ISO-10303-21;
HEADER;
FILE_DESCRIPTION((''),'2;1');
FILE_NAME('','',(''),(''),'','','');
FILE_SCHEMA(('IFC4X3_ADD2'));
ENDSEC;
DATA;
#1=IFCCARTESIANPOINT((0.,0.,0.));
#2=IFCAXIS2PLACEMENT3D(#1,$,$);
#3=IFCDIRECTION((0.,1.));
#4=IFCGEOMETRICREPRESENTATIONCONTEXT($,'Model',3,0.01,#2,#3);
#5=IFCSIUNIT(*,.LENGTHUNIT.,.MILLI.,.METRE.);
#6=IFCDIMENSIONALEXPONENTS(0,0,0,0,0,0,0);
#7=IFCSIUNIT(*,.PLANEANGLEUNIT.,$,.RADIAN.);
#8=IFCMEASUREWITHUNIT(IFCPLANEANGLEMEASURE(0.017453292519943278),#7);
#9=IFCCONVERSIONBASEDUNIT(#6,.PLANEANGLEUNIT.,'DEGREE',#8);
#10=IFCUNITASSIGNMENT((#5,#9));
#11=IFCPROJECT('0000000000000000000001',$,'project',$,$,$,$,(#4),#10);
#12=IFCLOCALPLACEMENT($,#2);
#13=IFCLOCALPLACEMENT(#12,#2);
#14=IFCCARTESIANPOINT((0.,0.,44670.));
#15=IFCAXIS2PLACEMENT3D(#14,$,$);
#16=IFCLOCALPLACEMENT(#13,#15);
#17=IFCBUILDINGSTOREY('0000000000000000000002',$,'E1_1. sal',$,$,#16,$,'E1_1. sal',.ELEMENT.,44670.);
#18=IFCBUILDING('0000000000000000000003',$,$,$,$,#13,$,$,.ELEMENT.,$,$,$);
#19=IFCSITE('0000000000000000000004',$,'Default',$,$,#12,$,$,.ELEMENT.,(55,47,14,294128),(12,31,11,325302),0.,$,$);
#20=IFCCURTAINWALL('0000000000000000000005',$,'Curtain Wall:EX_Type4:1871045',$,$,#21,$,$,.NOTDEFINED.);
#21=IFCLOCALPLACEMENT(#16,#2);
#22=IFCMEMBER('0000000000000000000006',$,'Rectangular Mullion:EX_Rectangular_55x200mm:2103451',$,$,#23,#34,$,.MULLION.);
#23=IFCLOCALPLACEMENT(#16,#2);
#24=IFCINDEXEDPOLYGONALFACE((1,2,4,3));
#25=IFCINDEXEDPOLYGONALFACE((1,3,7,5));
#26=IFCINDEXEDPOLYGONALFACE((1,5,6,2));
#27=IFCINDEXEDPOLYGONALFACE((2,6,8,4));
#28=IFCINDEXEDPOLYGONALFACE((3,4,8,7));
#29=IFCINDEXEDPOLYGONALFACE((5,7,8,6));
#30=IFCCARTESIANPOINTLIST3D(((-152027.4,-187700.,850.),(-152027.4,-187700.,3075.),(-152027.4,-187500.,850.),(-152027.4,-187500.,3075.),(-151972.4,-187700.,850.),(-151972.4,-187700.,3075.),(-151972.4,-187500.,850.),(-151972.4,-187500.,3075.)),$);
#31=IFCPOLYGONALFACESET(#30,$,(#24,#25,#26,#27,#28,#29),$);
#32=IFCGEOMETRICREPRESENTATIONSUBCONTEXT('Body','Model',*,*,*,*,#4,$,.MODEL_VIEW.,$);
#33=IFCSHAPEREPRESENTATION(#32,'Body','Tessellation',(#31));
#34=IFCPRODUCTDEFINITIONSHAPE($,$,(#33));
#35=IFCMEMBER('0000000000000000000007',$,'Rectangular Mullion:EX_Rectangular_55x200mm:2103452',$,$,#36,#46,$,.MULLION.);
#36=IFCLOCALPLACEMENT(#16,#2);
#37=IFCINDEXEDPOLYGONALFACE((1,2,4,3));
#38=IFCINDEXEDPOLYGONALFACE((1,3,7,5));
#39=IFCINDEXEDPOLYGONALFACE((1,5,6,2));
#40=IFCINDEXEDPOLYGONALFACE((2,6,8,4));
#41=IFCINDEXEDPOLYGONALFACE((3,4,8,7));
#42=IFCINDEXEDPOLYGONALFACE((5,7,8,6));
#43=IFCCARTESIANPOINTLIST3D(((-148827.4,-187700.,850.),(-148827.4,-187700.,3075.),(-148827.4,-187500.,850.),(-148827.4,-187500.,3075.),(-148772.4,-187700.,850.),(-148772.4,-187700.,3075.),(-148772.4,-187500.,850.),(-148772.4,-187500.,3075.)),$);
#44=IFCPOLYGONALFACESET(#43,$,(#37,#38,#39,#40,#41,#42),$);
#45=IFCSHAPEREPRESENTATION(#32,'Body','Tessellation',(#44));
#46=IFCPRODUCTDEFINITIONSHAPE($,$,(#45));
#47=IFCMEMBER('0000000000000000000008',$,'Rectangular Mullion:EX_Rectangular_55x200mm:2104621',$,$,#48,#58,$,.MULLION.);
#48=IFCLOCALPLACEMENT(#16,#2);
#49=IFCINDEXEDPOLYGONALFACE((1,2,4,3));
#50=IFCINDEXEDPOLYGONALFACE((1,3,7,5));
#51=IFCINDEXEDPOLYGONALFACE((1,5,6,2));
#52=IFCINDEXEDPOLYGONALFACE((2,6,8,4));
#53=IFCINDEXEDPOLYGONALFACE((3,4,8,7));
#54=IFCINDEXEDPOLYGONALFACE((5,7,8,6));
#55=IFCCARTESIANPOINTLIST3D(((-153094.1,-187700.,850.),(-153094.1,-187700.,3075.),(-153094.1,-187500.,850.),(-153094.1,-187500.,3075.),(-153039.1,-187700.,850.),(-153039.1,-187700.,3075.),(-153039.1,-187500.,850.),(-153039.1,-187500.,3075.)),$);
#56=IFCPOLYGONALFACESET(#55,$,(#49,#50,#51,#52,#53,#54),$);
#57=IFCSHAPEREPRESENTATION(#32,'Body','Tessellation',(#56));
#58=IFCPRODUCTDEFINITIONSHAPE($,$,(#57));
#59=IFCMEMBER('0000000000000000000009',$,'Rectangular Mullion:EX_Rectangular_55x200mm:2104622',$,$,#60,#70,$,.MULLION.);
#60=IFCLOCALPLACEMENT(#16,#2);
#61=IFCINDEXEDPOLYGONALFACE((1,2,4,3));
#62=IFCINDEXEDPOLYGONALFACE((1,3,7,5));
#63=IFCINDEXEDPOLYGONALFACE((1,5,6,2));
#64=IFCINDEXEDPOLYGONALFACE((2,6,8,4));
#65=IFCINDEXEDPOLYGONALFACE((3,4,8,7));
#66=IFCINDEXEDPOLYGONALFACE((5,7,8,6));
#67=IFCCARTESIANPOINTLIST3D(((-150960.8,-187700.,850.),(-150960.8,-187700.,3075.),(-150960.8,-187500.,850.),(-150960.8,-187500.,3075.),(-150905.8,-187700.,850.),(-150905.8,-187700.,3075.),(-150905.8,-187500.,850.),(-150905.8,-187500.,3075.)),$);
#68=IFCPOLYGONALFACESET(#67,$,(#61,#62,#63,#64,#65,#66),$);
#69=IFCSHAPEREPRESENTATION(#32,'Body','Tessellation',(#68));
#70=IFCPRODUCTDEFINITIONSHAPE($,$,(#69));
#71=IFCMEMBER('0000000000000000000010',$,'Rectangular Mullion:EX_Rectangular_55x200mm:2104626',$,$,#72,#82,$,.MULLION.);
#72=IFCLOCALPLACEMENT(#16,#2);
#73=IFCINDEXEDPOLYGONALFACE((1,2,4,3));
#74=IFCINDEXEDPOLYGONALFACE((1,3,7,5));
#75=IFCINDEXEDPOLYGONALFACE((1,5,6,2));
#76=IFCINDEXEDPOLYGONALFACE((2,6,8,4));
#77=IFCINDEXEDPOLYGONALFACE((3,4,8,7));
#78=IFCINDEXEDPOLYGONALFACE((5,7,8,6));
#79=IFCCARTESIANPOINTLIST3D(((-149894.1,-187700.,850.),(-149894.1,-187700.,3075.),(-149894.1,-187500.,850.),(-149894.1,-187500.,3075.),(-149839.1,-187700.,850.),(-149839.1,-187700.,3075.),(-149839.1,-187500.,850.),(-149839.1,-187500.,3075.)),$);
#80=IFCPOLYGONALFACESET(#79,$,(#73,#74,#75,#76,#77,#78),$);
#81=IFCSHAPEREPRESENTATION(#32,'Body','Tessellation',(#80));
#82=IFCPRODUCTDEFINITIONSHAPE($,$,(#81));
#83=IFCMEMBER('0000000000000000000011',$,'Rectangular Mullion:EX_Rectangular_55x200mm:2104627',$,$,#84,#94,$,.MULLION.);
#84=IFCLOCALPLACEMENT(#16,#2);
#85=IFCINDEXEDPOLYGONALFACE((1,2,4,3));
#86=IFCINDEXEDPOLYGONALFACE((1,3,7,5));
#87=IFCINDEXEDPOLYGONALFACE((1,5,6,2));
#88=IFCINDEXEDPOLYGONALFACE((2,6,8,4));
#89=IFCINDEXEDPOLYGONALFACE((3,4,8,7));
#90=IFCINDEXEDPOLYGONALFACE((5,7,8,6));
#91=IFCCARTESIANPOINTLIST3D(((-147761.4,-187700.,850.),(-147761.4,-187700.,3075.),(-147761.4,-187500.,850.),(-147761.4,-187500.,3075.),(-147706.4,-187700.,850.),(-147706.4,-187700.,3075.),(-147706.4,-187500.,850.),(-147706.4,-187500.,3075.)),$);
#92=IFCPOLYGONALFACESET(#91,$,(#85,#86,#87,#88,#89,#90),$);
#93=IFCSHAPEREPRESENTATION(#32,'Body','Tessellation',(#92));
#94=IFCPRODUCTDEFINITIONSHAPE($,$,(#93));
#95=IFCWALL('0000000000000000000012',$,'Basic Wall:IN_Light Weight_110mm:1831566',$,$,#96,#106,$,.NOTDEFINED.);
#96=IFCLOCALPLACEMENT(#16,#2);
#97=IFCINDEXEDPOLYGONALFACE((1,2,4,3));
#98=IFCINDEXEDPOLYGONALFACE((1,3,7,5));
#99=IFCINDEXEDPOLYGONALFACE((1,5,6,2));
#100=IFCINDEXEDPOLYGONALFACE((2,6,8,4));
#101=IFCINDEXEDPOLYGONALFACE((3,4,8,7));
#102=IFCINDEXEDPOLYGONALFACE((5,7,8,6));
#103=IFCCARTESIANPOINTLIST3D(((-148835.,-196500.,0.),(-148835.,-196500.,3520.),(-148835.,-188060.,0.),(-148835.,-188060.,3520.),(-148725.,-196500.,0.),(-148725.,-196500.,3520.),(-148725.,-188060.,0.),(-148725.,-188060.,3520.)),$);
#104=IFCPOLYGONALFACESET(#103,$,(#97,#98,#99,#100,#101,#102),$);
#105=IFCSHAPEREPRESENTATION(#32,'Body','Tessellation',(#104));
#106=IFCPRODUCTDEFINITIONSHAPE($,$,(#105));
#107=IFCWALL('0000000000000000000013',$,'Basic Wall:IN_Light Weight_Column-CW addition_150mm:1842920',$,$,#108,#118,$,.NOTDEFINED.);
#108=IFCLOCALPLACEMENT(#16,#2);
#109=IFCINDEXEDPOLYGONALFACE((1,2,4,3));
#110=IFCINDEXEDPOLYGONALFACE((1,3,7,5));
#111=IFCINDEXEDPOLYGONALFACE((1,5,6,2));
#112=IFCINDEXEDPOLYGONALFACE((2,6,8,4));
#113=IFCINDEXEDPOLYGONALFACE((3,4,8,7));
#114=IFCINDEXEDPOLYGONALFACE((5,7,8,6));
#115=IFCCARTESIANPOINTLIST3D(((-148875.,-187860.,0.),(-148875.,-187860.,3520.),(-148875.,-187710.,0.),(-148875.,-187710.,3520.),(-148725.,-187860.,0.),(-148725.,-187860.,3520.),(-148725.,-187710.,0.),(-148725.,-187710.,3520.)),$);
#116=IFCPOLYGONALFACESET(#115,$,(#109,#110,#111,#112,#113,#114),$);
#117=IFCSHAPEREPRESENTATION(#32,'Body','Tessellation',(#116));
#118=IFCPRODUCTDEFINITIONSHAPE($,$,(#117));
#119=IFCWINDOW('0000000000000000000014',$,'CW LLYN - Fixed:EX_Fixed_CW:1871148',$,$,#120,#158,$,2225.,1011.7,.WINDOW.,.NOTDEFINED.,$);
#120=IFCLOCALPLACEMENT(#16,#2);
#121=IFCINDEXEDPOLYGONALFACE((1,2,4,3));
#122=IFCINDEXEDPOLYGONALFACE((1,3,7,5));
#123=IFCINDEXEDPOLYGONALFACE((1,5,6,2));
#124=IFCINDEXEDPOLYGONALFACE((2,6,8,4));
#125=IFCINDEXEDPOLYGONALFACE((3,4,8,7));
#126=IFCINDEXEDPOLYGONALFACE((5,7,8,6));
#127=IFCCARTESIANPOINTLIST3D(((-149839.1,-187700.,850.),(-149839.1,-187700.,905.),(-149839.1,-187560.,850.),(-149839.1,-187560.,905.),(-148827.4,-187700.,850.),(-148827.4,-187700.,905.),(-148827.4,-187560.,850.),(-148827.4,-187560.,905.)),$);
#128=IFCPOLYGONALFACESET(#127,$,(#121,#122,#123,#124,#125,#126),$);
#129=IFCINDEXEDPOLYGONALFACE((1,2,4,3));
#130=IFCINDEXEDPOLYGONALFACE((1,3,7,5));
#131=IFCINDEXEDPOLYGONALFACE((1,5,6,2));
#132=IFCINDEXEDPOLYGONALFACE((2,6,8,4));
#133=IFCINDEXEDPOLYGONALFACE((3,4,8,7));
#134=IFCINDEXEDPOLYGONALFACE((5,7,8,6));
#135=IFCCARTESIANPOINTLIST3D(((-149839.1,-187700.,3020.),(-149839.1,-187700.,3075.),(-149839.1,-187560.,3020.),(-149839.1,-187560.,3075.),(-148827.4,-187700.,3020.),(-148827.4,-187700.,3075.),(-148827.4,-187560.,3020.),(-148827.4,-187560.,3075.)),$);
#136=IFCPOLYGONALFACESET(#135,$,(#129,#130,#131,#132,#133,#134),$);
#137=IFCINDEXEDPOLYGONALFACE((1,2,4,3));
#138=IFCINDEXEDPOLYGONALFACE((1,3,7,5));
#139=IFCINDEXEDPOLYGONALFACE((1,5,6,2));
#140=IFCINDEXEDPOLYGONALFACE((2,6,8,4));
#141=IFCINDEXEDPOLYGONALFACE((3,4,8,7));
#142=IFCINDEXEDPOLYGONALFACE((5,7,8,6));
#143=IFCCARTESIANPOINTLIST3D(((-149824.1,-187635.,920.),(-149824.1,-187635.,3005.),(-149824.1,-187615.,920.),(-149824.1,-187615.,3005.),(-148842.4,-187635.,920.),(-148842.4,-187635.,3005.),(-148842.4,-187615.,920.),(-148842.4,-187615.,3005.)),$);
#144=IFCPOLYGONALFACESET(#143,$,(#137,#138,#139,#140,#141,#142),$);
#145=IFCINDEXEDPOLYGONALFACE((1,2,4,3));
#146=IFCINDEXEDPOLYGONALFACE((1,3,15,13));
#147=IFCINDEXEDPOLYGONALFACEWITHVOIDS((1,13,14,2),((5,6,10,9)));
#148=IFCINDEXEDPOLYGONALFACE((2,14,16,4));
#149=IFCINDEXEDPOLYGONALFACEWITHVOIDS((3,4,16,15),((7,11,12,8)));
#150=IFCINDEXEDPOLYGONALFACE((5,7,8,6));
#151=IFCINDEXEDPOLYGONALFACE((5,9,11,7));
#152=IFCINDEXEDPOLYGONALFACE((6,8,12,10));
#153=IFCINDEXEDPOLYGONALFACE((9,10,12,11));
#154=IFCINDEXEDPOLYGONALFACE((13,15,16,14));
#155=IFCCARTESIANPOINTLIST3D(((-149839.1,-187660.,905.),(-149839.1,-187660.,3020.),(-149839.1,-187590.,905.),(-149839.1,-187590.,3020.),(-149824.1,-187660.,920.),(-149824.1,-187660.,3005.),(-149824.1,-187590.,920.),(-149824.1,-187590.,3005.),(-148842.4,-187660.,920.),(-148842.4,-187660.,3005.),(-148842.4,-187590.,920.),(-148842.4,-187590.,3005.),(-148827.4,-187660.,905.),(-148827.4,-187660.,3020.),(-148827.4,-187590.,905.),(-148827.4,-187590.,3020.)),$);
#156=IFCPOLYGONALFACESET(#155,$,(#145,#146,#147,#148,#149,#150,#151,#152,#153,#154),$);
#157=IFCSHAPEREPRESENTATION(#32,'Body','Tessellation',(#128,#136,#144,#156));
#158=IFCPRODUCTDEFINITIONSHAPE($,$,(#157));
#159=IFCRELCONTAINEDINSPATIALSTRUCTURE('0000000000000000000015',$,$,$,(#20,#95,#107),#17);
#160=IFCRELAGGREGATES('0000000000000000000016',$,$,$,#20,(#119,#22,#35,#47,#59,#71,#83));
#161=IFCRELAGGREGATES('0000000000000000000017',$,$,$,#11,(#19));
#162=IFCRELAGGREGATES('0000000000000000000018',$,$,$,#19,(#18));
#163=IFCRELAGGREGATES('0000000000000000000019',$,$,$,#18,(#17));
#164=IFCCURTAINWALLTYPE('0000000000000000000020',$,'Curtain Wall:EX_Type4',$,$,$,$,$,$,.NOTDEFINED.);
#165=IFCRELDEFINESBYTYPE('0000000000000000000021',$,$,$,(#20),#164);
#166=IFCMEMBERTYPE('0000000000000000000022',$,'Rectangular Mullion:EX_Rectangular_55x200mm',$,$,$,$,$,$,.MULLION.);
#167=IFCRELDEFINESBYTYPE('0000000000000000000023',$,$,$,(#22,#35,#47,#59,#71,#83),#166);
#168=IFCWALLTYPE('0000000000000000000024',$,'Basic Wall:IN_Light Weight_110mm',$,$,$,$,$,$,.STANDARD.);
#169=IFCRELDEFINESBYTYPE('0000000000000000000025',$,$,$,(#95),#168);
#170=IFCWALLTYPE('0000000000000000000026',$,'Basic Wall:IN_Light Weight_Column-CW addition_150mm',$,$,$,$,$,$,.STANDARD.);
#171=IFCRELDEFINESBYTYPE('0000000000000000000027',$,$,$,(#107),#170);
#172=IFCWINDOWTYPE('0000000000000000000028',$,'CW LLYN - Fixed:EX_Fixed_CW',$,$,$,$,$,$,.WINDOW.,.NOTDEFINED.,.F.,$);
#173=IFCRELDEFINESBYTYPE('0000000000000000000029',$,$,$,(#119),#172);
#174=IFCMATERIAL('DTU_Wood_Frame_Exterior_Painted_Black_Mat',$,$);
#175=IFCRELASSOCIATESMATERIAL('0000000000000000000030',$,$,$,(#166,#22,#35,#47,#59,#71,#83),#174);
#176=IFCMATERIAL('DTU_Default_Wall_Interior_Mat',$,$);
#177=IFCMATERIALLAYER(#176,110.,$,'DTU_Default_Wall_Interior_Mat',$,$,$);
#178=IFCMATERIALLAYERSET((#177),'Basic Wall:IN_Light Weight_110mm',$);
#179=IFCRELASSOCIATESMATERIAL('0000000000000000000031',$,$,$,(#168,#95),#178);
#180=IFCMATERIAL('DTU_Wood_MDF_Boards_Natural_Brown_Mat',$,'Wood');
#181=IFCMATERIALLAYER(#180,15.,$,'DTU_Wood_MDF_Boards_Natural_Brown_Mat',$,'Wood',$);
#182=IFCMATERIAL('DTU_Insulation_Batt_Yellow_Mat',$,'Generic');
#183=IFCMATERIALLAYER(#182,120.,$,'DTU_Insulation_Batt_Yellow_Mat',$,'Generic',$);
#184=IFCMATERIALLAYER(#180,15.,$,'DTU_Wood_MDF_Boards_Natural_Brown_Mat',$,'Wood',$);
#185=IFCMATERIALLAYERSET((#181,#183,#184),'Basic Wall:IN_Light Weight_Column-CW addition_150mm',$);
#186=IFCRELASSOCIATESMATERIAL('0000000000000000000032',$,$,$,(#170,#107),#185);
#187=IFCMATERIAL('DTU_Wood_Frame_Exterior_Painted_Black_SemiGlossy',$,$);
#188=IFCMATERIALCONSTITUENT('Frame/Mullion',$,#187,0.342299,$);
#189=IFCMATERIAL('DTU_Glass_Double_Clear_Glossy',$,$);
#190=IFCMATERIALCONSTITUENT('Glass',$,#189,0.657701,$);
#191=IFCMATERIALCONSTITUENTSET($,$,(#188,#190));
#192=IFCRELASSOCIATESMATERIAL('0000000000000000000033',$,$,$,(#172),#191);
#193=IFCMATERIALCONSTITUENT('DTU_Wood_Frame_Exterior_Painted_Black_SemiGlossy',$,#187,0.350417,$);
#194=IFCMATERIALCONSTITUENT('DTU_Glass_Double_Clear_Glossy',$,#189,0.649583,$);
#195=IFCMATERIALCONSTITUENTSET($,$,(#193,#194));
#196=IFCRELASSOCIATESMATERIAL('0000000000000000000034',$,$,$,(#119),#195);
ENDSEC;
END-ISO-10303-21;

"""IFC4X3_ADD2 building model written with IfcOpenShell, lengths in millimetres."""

from ifc_helpers import new_model, entity, si_unit, converted_unit, direction, frame, frame_2d, origin, origin_2d_with_axis, place, context, subcontext, project, spatial, polyline, rectangle, outline, extrude, source, transform, mapped, material, layer, layer_set, constituent, constituent_set, material_profile, profile_set, profile_usage, type_object, type_shapes, element, aggregate, save


model = new_model("IFC4X3_ADD2")

# Units and contexts
model_context = context("Model", 3, precision=0.01, world=origin(), true_north=direction((0.0, 1.0)))
body_context = subcontext(model_context, "Body", "Model", "MODEL_VIEW")
ifc_project = project(units=[si_unit("LENGTHUNIT", "METRE", prefix="MILLI"), converted_unit("PLANEANGLEUNIT", "DEGREE", entity("IfcPlaneAngleMeasure", 0.017453292519943278), si_unit("PLANEANGLEUNIT", "RADIAN"), dimensions=[0, 0, 0, 0, 0, 0, 0])], contexts=[model_context])

# Site, building, storey
site_placement = place(None, origin())
site = spatial("IfcSite", under=ifc_project, at=site_placement, Name="Default", CompositionType="ELEMENT", RefLatitude=(55, 47, 14, 294128), RefLongitude=(12, 31, 11, 325302), RefElevation=0.0)
building_placement = place(site_placement, origin())
building = spatial("IfcBuilding", under=site, at=building_placement, CompositionType="ELEMENT")
storey_placement = place(building_placement, frame((0.0, 0.0, 44670.0)))
storey = spatial("IfcBuildingStorey", under=building, at=storey_placement, Name="E1_1. sal", LongName="E1_1. sal", CompositionType="ELEMENT", Elevation=44670.0)

# Curtain wall, members
curtain_wall_type = type_object("IfcCurtainWallType", Name="Curtain Wall:EX_Type4", PredefinedType="NOTDEFINED")
curtain_wall_placement = place(storey_placement, frame((0.0, 0.0, -44670.0)))
curtain_wall = element("IfcCurtainWall", 1, at=curtain_wall_placement, inside=storey, type_object=curtain_wall_type, Name="Curtain Wall:EX_Type4:1871045", PredefinedType="NOTDEFINED")
ifc_material_1 = material(Name="DTU_Wood_Frame_Exterior_Painted_Black_Mat")
ifc_material_profile = material_profile(ifc_material_1, rectangle(XDim=55.0, YDim=200.0, at=origin_2d_with_axis()), Name="EX_Rectangular_55x200mm")
ifc_profile_set = profile_set([ifc_material_profile], Name="EX_Rectangular_55x200mm")
ifc_profile_usage = profile_usage(ifc_profile_set)
member_type = type_object("IfcMemberType", Name="Rectangular Mullion:EX_Rectangular_55x200mm", PredefinedType="MULLION", material=ifc_profile_set)
shared_shape_1 = source(origin(), body_context, "Body", "SweptSolid", [
    extrude(rectangle(XDim=55.0, YDim=200.0, at=origin_2d_with_axis()), frame((0.0, -100.0, -2225.0), z_axis=(0.0, 0.0, 1.0), x_axis=(-1.0, 0.0, 0.0)), (0.0, 0.0, 1.0), 2225.0),
])
type_shapes(member_type, [shared_shape_1])
member_1_placement = place(curtain_wall_placement, frame((-151999.9, -187500.0, 45520.0), z_axis=(0.0, 0.0, -1.0), x_axis=(-1.0, 0.0, 0.0)))
member_1 = element("IfcMember", 2, at=member_1_placement, type_object=member_type, material=ifc_profile_usage, Name="Rectangular Mullion:EX_Rectangular_55x200mm:2103451", PredefinedType="MULLION", context=body_context, shape_type="MappedRepresentation", body=[
    mapped(shared_shape_1, transform((0.0, 0.0, 0.0), scale=1.0)),
])
member_2_placement = place(curtain_wall_placement, frame((-148799.9, -187500.0, 45520.0), z_axis=(0.0, 0.0, -1.0), x_axis=(-1.0, 0.0, 0.0)))
member_2 = element("IfcMember", 3, at=member_2_placement, type_object=member_type, material=ifc_profile_usage, Name="Rectangular Mullion:EX_Rectangular_55x200mm:2103452", PredefinedType="MULLION", context=body_context, shape_type="MappedRepresentation", body=[
    mapped(shared_shape_1, transform((0.0, 0.0, 0.0), scale=1.0)),
])
member_3_placement = place(curtain_wall_placement, frame((-153066.6, -187500.0, 45520.0), z_axis=(0.0, 0.0, -1.0), x_axis=(-1.0, 0.0, 0.0)))
member_3 = element("IfcMember", 4, at=member_3_placement, type_object=member_type, material=ifc_profile_usage, Name="Rectangular Mullion:EX_Rectangular_55x200mm:2104621", PredefinedType="MULLION", context=body_context, shape_type="MappedRepresentation", body=[
    mapped(shared_shape_1, transform((0.0, 0.0, 0.0), scale=1.0)),
])
member_4_placement = place(curtain_wall_placement, frame((-150933.3, -187500.0, 45520.0), z_axis=(0.0, 0.0, -1.0), x_axis=(-1.0, 0.0, 0.0)))
member_4 = element("IfcMember", 5, at=member_4_placement, type_object=member_type, material=ifc_profile_usage, Name="Rectangular Mullion:EX_Rectangular_55x200mm:2104622", PredefinedType="MULLION", context=body_context, shape_type="MappedRepresentation", body=[
    mapped(shared_shape_1, transform((0.0, 0.0, 0.0), scale=1.0)),
])
member_5_placement = place(curtain_wall_placement, frame((-149866.6, -187500.0, 45520.0), z_axis=(0.0, 0.0, -1.0), x_axis=(-1.0, 0.0, 0.0)))
member_5 = element("IfcMember", 6, at=member_5_placement, type_object=member_type, material=ifc_profile_usage, Name="Rectangular Mullion:EX_Rectangular_55x200mm:2104626", PredefinedType="MULLION", context=body_context, shape_type="MappedRepresentation", body=[
    mapped(shared_shape_1, transform((0.0, 0.0, 0.0), scale=1.0)),
])
member_6_placement = place(curtain_wall_placement, frame((-147733.9, -187500.0, 45520.0), z_axis=(0.0, 0.0, -1.0), x_axis=(-1.0, 0.0, 0.0)))
member_6 = element("IfcMember", 7, at=member_6_placement, type_object=member_type, material=ifc_profile_usage, Name="Rectangular Mullion:EX_Rectangular_55x200mm:2104627", PredefinedType="MULLION", context=body_context, shape_type="MappedRepresentation", body=[
    mapped(shared_shape_1, transform((0.0, 0.0, 0.0), scale=1.0)),
])

# Walls
ifc_material_2 = material(Name="DTU_Default_Wall_Interior_Mat")
ifc_layer_1 = layer(ifc_material_2, 110.0, Name="DTU_Default_Wall_Interior_Mat")
ifc_layer_set_1 = layer_set([ifc_layer_1], Name="Basic Wall:IN_Light Weight_110mm")
wall_type_1 = type_object("IfcWallType", Name="Basic Wall:IN_Light Weight_110mm", PredefinedType="STANDARD", material=ifc_layer_set_1)
wall_1_placement = place(storey_placement, frame((-148780.0, -188060.0, 0.0), z_axis=(0.0, 0.0, 1.0), x_axis=(0.0, -1.0, 0.0)))
element("IfcWall", 8, at=wall_1_placement, inside=storey, type_object=wall_type_1, material=ifc_layer_set_1, Name="Basic Wall:IN_Light Weight_110mm:1831566", PredefinedType="NOTDEFINED", context=body_context, shape_type="SweptSolid", body=[
    extrude(rectangle(XDim=8440.0, YDim=110.0, at=frame_2d((4220.0, 0.0), x_axis=(-1.0, 0.0))), origin(), (0.0, 0.0, 1.0), 3520.0),
])
ifc_material_3 = material(Name="DTU_Wood_MDF_Boards_Natural_Brown_Mat", Category="Wood")
ifc_layer_2 = layer(ifc_material_3, 15.0, Name="DTU_Wood_MDF_Boards_Natural_Brown_Mat", Category="Wood")
ifc_material_4 = material(Name="DTU_Insulation_Batt_Yellow_Mat", Category="Generic")
ifc_layer_3 = layer(ifc_material_4, 120.0, Name="DTU_Insulation_Batt_Yellow_Mat", Category="Generic")
ifc_layer_4 = layer(ifc_material_3, 15.0, Name="DTU_Wood_MDF_Boards_Natural_Brown_Mat", Category="Wood")
ifc_layer_set_2 = layer_set([ifc_layer_2, ifc_layer_3, ifc_layer_4], Name="Basic Wall:IN_Light Weight_Column-CW addition_150mm")
wall_type_2 = type_object("IfcWallType", Name="Basic Wall:IN_Light Weight_Column-CW addition_150mm", PredefinedType="STANDARD", material=ifc_layer_set_2)
wall_2_placement = place(storey_placement, frame((-148800.0, -187710.0, 0.0), z_axis=(0.0, 0.0, 1.0), x_axis=(0.0, -1.0, 0.0)))
element("IfcWall", 9, at=wall_2_placement, inside=storey, type_object=wall_type_2, material=ifc_layer_set_2, Name="Basic Wall:IN_Light Weight_Column-CW addition_150mm:1842920", PredefinedType="NOTDEFINED", context=body_context, shape_type="SweptSolid", body=[
    extrude(rectangle(XDim=150.0, YDim=150.0, at=frame_2d((75.0, 0.0), x_axis=(-1.0, 0.0))), origin(), (0.0, 0.0, 1.0), 3520.0),
])

# Window
ifc_material_5 = material(Name="DTU_Wood_Frame_Exterior_Painted_Black_SemiGlossy")
ifc_constituent_1 = constituent(ifc_material_5, Name="DTU_Wood_Frame_Exterior_Painted_Black_SemiGlossy", fraction=0.350417)
ifc_material_6 = material(Name="DTU_Glass_Double_Clear_Glossy")
ifc_constituent_2 = constituent(ifc_material_6, Name="DTU_Glass_Double_Clear_Glossy", fraction=0.649583)
ifc_constituent_set_1 = constituent_set(constituents=[ifc_constituent_1, ifc_constituent_2])
ifc_constituent_3 = constituent(ifc_material_5, Name="Frame/Mullion", fraction=0.342299)
ifc_constituent_4 = constituent(ifc_material_6, Name="Glass", fraction=0.657701)
ifc_constituent_set_2 = constituent_set(constituents=[ifc_constituent_3, ifc_constituent_4])
window_type_1 = type_object("IfcWindowType", Name="CW LLYN - Fixed:EX_Fixed_CW", ParameterTakesPrecedence=False, PartitioningType="NOTDEFINED", PredefinedType="WINDOW", material=ifc_constituent_set_2)
shared_shape_2 = source(origin(), body_context, "Body", "SweptSolid", [
    extrude(rectangle(XDim=140.0, YDim=1011.7, at=origin_2d_with_axis()), frame((0.0, -130.0, 0.0), z_axis=(0.0, 0.0, 1.0), x_axis=(0.0, -1.0, 0.0)), (0.0, 0.0, 1.0), 55.0),
    extrude(rectangle(XDim=140.0, YDim=1011.7, at=frame_2d((0.0, 0.0), x_axis=(1.0, 0.0))), frame((0.0, -130.0, 2170.0), z_axis=(0.0, 0.0, 1.0), x_axis=(0.0, -1.0, 0.0)), (0.0, 0.0, 1.0), 55.0),
    extrude(rectangle(XDim=981.7, YDim=20.0, at=frame_2d((0.0, 0.0), x_axis=(1.0, 0.0))), frame((0.0, -125.0, 70.0), z_axis=(0.0, 0.0, 1.0), x_axis=(-1.0, 0.0, 0.0)), (0.0, 0.0, 1.0), 2085.0),
    extrude(outline(polyline([(-1057.5, -505.8), (1057.5, -505.8), (1057.5, 505.8), (-1057.5, 505.8), (-1057.5, -505.8)]), holes=[polyline([(-1042.5, 490.8), (1042.5, 490.8), (1042.5, -490.8), (-1042.5, -490.8), (-1042.5, 490.8)])]), frame((0.0, -90.0, 1112.5), z_axis=(0.0, -1.0, 0.0), x_axis=(0.0, 0.0, 1.0)), (0.0, 0.0, 1.0), 70.0),
])
type_shapes(window_type_1, [shared_shape_2])
window_1_placement = place(curtain_wall_placement, frame((-149333.3, -187500.0, 45520.0)))
window_1 = element("IfcWindow", 10, at=window_1_placement, type_object=window_type_1, material=ifc_constituent_set_1, Name="CW LLYN - Fixed:EX_Fixed_CW:1871148", OverallHeight=2225.0, OverallWidth=1011.7, PartitioningType="NOTDEFINED", PredefinedType="WINDOW", context=body_context, shape_type="MappedRepresentation", body=[
    mapped(shared_shape_2, transform((0.0, 0.0, 0.0), scale=1.0)),
])

aggregate(curtain_wall, [window_1, member_1, member_2, member_3, member_4, member_5, member_6])

save(model, "model.ifc")
